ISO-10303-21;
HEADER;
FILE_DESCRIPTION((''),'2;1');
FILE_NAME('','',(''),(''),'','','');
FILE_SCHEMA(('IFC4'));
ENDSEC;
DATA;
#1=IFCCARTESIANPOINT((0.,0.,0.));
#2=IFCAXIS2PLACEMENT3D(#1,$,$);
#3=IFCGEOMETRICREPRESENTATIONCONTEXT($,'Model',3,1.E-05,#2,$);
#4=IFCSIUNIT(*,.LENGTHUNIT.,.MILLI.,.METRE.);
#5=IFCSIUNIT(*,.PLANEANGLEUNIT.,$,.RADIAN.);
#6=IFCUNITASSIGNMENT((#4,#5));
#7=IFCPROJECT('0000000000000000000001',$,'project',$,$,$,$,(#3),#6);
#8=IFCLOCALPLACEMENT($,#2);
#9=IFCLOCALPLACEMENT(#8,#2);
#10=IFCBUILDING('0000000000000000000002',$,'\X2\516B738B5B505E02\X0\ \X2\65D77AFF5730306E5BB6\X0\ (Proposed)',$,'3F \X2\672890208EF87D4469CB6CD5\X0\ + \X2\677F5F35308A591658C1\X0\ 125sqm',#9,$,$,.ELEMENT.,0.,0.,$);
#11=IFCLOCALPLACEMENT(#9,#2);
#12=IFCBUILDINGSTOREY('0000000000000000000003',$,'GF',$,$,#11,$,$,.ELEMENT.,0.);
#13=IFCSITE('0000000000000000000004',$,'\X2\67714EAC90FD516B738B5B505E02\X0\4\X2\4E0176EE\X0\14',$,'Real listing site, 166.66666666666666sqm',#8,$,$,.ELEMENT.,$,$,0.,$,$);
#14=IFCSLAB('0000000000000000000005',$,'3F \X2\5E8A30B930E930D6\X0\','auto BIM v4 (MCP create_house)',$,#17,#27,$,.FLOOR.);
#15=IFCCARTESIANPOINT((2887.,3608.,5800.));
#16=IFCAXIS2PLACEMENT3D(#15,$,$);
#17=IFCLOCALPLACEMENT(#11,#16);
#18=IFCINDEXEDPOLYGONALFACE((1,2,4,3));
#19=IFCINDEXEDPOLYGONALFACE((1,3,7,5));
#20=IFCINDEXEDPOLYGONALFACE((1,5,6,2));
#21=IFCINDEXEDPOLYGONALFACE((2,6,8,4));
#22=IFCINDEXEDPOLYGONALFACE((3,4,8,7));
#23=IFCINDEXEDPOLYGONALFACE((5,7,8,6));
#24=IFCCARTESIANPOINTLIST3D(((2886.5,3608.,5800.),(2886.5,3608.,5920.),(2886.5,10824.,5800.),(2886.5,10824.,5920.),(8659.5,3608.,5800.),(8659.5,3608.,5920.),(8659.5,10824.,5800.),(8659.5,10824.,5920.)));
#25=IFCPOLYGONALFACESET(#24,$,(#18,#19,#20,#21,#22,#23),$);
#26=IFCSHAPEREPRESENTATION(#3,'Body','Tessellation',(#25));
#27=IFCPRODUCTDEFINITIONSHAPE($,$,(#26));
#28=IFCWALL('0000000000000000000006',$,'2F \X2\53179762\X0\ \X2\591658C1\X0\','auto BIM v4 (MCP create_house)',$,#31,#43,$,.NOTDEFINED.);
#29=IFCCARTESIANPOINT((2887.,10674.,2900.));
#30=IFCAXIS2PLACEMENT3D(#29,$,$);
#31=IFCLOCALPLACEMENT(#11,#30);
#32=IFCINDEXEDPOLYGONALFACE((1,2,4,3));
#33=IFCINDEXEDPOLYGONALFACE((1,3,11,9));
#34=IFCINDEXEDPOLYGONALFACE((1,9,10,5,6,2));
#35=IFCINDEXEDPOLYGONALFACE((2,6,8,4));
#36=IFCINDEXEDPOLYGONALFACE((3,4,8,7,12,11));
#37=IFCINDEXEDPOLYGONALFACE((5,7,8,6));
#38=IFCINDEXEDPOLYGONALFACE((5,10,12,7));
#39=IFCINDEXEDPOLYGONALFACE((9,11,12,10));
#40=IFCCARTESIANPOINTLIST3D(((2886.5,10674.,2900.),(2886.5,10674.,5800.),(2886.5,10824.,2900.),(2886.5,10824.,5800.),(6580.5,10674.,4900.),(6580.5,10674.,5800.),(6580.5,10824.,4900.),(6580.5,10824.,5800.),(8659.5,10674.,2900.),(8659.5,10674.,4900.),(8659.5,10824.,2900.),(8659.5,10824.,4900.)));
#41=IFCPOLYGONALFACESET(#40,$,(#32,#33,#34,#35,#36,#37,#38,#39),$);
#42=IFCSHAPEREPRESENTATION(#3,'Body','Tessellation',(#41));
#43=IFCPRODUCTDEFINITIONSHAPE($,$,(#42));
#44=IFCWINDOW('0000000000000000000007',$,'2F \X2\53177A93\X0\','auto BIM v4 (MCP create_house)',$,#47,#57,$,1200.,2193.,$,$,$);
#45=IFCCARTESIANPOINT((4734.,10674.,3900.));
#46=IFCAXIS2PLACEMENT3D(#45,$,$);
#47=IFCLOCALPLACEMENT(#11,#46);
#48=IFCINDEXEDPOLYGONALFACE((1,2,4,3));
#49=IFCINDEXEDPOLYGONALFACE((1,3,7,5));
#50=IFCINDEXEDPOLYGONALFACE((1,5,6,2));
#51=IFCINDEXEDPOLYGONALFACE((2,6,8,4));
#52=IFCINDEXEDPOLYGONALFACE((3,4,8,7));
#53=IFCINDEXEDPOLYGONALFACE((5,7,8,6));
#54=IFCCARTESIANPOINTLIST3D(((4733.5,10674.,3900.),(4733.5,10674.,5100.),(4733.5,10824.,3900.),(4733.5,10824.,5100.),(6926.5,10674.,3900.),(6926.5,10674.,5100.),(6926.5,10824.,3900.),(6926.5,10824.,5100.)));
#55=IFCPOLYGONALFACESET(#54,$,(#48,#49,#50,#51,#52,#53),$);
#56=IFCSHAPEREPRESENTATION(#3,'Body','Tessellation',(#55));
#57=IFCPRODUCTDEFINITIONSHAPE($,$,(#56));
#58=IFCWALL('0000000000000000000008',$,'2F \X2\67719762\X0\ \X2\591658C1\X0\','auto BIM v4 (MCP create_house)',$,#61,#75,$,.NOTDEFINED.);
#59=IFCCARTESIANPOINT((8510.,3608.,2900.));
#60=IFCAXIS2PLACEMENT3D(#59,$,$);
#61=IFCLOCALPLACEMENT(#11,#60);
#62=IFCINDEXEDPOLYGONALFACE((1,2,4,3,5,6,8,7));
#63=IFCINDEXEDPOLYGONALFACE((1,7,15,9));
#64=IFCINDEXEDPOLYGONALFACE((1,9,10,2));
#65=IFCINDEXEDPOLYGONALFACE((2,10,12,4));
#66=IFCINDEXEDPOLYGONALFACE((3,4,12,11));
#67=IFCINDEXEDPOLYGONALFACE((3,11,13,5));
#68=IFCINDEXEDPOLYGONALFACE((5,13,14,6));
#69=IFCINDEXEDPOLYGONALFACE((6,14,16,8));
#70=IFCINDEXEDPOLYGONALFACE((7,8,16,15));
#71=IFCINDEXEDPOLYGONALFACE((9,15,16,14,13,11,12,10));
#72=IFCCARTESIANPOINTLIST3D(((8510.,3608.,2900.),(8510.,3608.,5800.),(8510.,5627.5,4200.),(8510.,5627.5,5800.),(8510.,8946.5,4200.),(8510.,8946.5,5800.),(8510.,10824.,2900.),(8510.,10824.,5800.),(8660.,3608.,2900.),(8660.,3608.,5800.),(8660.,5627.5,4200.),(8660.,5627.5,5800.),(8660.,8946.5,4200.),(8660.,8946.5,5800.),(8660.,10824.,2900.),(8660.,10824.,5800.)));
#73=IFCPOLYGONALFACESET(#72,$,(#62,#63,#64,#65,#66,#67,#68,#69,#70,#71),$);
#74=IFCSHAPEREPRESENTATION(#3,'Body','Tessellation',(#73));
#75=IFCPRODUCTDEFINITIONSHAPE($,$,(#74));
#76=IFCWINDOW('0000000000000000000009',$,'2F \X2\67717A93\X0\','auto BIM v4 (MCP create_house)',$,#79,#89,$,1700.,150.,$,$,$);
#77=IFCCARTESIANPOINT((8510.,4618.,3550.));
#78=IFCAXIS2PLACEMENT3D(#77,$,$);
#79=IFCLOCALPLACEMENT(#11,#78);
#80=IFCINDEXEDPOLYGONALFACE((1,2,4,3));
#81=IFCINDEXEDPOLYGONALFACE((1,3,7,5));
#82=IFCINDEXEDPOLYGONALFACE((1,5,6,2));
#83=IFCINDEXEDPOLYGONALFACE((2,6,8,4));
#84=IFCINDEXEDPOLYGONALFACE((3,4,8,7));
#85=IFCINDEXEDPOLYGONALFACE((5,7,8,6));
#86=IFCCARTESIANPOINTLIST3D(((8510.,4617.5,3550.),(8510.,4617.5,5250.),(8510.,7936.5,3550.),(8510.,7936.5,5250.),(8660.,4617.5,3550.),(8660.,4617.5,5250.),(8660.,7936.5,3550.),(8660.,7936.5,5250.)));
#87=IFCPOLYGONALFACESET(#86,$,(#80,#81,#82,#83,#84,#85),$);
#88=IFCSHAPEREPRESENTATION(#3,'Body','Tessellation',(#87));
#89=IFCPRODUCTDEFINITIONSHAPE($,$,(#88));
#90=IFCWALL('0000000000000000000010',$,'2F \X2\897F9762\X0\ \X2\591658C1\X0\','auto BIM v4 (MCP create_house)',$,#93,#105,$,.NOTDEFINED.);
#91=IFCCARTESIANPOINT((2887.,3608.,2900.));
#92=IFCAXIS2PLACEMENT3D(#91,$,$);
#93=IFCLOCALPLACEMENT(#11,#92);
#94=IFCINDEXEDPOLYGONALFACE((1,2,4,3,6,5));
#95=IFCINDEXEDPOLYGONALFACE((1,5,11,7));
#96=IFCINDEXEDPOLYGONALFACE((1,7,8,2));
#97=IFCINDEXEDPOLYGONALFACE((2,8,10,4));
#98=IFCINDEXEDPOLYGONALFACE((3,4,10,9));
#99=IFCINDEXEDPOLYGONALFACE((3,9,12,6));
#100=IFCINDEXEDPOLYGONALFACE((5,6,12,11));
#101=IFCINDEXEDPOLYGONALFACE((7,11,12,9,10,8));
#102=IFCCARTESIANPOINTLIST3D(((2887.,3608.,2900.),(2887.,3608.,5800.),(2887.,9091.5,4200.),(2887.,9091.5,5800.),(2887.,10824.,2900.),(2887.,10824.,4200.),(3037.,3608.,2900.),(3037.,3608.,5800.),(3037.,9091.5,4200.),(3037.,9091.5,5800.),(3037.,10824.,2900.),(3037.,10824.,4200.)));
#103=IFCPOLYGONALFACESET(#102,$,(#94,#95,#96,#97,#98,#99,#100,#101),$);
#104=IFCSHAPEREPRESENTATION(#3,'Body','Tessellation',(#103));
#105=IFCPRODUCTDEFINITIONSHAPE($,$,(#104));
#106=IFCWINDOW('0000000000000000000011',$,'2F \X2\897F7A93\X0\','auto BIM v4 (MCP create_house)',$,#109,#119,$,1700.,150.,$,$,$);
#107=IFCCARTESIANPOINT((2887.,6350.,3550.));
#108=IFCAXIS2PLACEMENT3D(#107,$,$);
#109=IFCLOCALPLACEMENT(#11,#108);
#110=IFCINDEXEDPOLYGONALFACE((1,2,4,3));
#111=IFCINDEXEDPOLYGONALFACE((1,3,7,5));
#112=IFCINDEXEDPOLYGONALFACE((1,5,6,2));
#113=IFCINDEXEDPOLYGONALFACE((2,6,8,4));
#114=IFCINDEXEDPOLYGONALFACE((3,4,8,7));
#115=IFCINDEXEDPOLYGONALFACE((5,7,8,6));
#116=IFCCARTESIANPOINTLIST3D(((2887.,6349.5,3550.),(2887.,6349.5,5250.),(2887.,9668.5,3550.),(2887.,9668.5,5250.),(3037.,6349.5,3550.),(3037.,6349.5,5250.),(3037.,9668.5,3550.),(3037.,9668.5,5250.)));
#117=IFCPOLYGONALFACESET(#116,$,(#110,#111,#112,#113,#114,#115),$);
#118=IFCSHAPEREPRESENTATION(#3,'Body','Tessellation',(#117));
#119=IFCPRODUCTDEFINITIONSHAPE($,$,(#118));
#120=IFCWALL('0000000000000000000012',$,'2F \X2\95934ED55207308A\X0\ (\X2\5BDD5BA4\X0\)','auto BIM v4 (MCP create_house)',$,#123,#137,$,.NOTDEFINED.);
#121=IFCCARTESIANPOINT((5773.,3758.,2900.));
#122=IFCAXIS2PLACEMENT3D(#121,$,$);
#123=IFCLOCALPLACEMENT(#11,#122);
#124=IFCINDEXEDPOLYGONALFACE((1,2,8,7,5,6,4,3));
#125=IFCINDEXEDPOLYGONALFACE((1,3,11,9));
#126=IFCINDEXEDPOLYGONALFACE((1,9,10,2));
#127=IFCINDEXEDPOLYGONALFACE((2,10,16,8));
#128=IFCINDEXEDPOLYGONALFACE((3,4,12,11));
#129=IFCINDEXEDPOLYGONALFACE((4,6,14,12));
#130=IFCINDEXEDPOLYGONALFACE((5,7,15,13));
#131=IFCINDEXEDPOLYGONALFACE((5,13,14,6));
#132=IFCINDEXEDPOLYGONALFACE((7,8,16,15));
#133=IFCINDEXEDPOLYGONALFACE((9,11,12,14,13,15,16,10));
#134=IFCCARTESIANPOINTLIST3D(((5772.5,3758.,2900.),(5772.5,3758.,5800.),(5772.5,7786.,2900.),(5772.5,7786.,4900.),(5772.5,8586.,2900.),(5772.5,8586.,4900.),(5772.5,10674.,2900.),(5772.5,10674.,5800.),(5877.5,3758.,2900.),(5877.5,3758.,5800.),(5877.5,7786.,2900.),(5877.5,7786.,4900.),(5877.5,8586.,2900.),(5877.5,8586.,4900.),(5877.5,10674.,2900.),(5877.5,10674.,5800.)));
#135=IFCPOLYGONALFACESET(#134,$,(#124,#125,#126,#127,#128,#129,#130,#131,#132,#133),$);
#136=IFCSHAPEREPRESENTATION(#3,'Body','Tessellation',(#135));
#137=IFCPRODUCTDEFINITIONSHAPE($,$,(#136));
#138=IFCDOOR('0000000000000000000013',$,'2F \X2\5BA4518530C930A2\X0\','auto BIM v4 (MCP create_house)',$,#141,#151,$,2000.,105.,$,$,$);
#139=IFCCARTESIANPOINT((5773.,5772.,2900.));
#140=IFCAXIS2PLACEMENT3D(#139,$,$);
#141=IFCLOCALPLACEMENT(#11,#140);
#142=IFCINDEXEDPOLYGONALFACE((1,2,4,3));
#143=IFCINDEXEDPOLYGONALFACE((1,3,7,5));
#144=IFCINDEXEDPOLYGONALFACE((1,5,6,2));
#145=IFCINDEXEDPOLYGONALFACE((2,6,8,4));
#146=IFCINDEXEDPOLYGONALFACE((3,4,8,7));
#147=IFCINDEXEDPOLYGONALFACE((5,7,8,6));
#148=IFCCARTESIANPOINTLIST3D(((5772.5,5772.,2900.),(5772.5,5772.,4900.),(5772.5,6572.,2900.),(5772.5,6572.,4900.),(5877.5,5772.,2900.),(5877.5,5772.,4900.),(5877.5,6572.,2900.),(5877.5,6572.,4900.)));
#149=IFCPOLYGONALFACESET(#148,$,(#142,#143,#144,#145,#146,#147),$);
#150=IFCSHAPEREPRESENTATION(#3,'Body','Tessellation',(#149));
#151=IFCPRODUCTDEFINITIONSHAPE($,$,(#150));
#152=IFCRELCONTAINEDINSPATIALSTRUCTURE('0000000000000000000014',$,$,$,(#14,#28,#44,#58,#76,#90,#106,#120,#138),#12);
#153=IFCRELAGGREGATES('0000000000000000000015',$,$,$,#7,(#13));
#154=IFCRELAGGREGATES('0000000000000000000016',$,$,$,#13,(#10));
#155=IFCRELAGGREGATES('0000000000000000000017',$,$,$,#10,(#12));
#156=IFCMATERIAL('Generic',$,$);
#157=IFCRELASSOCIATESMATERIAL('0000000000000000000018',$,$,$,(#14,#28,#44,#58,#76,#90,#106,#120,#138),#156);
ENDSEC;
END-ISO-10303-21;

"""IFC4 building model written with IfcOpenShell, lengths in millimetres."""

from ifc_helpers import new_model, si_unit, frame, frame_2d, origin, place, context, project, spatial, rectangle, extrude, material, element, fill, save


model = new_model("IFC4")

# Units and contexts
model_context = context("Model", 3, precision=1e-05, world=origin())
ifc_project = project(units=[si_unit("LENGTHUNIT", "METRE", prefix="MILLI"), si_unit("PLANEANGLEUNIT", "RADIAN")], contexts=[model_context])

# Site, building, storey
site_placement = place(None, origin())
site = spatial("IfcSite", under=ifc_project, at=site_placement, Name="東京都八王子市4丁目14", ObjectType="Real listing site, 166.66666666666666sqm", CompositionType="ELEMENT", RefElevation=0.0)
building_placement = place(site_placement, origin())
building = spatial("IfcBuilding", under=site, at=building_placement, Name="八王子市 旗竿地の家 (Proposed)", ObjectType="3F 木造軸組構法 + 板張り外壁 125sqm", CompositionType="ELEMENT", ElevationOfRefHeight=0.0, ElevationOfTerrain=0.0)
storey_placement = place(building_placement, origin())
storey = spatial("IfcBuildingStorey", under=building, at=storey_placement, Name="GF", CompositionType="ELEMENT", Elevation=0.0)

# Slab
ifc_material = material(Name="Generic")
slab_placement = place(storey_placement, frame((2887.0, 3608.0, 5800.0)))
element("IfcSlab", 1, at=slab_placement, inside=storey, material=ifc_material, Name="3F 床スラブ", Description="auto BIM v4 (MCP create_house)", PredefinedType="FLOOR", context=model_context, shape_type="SweptSolid", body=[
    extrude(rectangle(XDim=5773.0, YDim=7216.0, at=frame_2d((2886.0, 3608.0))), frame((2887.0, 3608.0, 5800.0)), (0.0, 0.0, 1.0), 120.0),
])

# Walls, openings, windows
wall_1_placement = place(storey_placement, frame((2887.0, 10674.0, 2900.0)))
wall_1 = element("IfcWall", 2, at=wall_1_placement, inside=storey, material=ifc_material, Name="2F 北面 外壁", Description="auto BIM v4 (MCP create_house)", PredefinedType="NOTDEFINED", context=model_context, shape_type="SweptSolid", body=[
    extrude(rectangle(XDim=5773.0, YDim=150.0, at=frame_2d((2886.0, 75.0))), frame((2887.0, 10674.0, 2900.0)), (0.0, 0.0, 1.0), 2900.0),
])
opening_1_placement = place(storey_placement, frame((4734.0, 10674.0, 3900.0)))
opening_1 = element("IfcOpeningElement", 3, at=opening_1_placement, cuts=wall_1, PredefinedType="NOTDEFINED", context=model_context, shape_type="SweptSolid", body=[
    extrude(rectangle(XDim=2193.0, YDim=150.0, at=frame_2d((1096.0, 75.0))), frame((4734.0, 10674.0, 3900.0)), (0.0, 0.0, 1.0), 1200.0),
])
window_1_placement = place(storey_placement, frame((4734.0, 10674.0, 3900.0)))
window_1 = element("IfcWindow", 4, at=window_1_placement, inside=storey, material=ifc_material, Name="2F 北窓", Description="auto BIM v4 (MCP create_house)", OverallHeight=1200.0, OverallWidth=2193.0, context=model_context, shape_type="SweptSolid", body=[
    extrude(rectangle(XDim=2193.0, YDim=150.0, at=frame_2d((1096.0, 75.0))), frame((4734.0, 10674.0, 3900.0)), (0.0, 0.0, 1.0), 1200.0),
])
fill(opening_1, window_1)
wall_2_placement = place(storey_placement, frame((8510.0, 3608.0, 2900.0)))
wall_2 = element("IfcWall", 5, at=wall_2_placement, inside=storey, material=ifc_material, Name="2F 東面 外壁", Description="auto BIM v4 (MCP create_house)", PredefinedType="NOTDEFINED", context=model_context, shape_type="SweptSolid", body=[
    extrude(rectangle(XDim=150.0, YDim=7216.0, at=frame_2d((75.0, 3608.0))), frame((8510.0, 3608.0, 2900.0)), (0.0, 0.0, 1.0), 2900.0),
])
opening_2_placement = place(storey_placement, frame((8510.0, 4618.0, 3550.0)))
opening_2 = element("IfcOpeningElement", 6, at=opening_2_placement, cuts=wall_2, PredefinedType="NOTDEFINED", context=model_context, shape_type="SweptSolid", body=[
    extrude(rectangle(XDim=150.0, YDim=3319.0, at=frame_2d((75.0, 1659.0))), frame((8510.0, 4618.0, 3550.0)), (0.0, 0.0, 1.0), 1700.0),
])
window_2_placement = place(storey_placement, frame((8510.0, 4618.0, 3550.0)))
window_2 = element("IfcWindow", 7, at=window_2_placement, inside=storey, material=ifc_material, Name="2F 東窓", Description="auto BIM v4 (MCP create_house)", OverallHeight=1700.0, OverallWidth=150.0, context=model_context, shape_type="SweptSolid", body=[
    extrude(rectangle(XDim=150.0, YDim=3319.0, at=frame_2d((75.0, 1659.0))), frame((8510.0, 4618.0, 3550.0)), (0.0, 0.0, 1.0), 1700.0),
])
fill(opening_2, window_2)
wall_3_placement = place(storey_placement, frame((2887.0, 3608.0, 2900.0)))
wall_3 = element("IfcWall", 8, at=wall_3_placement, inside=storey, material=ifc_material, Name="2F 西面 外壁", Description="auto BIM v4 (MCP create_house)", PredefinedType="NOTDEFINED", context=model_context, shape_type="SweptSolid", body=[
    extrude(rectangle(XDim=150.0, YDim=7216.0, at=frame_2d((75.0, 3608.0))), frame((2887.0, 3608.0, 2900.0)), (0.0, 0.0, 1.0), 2900.0),
])
opening_3_placement = place(storey_placement, frame((2887.0, 6350.0, 3550.0)))
opening_3 = element("IfcOpeningElement", 9, at=opening_3_placement, cuts=wall_3, PredefinedType="NOTDEFINED", context=model_context, shape_type="SweptSolid", body=[
    extrude(rectangle(XDim=150.0, YDim=3319.0, at=frame_2d((75.0, 1659.0))), frame((2887.0, 6350.0, 3550.0)), (0.0, 0.0, 1.0), 1700.0),
])
window_3_placement = place(storey_placement, frame((2887.0, 6350.0, 3550.0)))
window_3 = element("IfcWindow", 10, at=window_3_placement, inside=storey, material=ifc_material, Name="2F 西窓", Description="auto BIM v4 (MCP create_house)", OverallHeight=1700.0, OverallWidth=150.0, context=model_context, shape_type="SweptSolid", body=[
    extrude(rectangle(XDim=150.0, YDim=3319.0, at=frame_2d((75.0, 1659.0))), frame((2887.0, 6350.0, 3550.0)), (0.0, 0.0, 1.0), 1700.0),
])
fill(opening_3, window_3)

# Wall, opening, door
wall_4_placement = place(storey_placement, frame((5773.0, 3758.0, 2900.0)))
wall_4 = element("IfcWall", 11, at=wall_4_placement, inside=storey, material=ifc_material, Name="2F 間仕切り (寝室)", Description="auto BIM v4 (MCP create_house)", PredefinedType="NOTDEFINED", context=model_context, shape_type="SweptSolid", body=[
    extrude(rectangle(XDim=105.0, YDim=6916.0, at=frame_2d((52.0, 3458.0))), frame((5773.0, 3758.0, 2900.0)), (0.0, 0.0, 1.0), 2900.0),
])
opening_4_placement = place(storey_placement, frame((5773.0, 5772.0, 2900.0)))
opening_4 = element("IfcOpeningElement", 12, at=opening_4_placement, cuts=wall_4, PredefinedType="NOTDEFINED", context=model_context, shape_type="SweptSolid", body=[
    extrude(rectangle(XDim=105.0, YDim=800.0, at=frame_2d((52.0, 400.0))), frame((5773.0, 5772.0, 2900.0)), (0.0, 0.0, 1.0), 2000.0),
])
door_1_placement = place(storey_placement, frame((5773.0, 5772.0, 2900.0)))
door_1 = element("IfcDoor", 13, at=door_1_placement, inside=storey, material=ifc_material, Name="2F 室内ドア", Description="auto BIM v4 (MCP create_house)", OverallHeight=2000.0, OverallWidth=105.0, context=model_context, shape_type="SweptSolid", body=[
    extrude(rectangle(XDim=105.0, YDim=800.0, at=frame_2d((52.0, 400.0))), frame((5773.0, 5772.0, 2900.0)), (0.0, 0.0, 1.0), 2000.0),
])
fill(opening_4, door_1)

save(model, "model.ifc")
